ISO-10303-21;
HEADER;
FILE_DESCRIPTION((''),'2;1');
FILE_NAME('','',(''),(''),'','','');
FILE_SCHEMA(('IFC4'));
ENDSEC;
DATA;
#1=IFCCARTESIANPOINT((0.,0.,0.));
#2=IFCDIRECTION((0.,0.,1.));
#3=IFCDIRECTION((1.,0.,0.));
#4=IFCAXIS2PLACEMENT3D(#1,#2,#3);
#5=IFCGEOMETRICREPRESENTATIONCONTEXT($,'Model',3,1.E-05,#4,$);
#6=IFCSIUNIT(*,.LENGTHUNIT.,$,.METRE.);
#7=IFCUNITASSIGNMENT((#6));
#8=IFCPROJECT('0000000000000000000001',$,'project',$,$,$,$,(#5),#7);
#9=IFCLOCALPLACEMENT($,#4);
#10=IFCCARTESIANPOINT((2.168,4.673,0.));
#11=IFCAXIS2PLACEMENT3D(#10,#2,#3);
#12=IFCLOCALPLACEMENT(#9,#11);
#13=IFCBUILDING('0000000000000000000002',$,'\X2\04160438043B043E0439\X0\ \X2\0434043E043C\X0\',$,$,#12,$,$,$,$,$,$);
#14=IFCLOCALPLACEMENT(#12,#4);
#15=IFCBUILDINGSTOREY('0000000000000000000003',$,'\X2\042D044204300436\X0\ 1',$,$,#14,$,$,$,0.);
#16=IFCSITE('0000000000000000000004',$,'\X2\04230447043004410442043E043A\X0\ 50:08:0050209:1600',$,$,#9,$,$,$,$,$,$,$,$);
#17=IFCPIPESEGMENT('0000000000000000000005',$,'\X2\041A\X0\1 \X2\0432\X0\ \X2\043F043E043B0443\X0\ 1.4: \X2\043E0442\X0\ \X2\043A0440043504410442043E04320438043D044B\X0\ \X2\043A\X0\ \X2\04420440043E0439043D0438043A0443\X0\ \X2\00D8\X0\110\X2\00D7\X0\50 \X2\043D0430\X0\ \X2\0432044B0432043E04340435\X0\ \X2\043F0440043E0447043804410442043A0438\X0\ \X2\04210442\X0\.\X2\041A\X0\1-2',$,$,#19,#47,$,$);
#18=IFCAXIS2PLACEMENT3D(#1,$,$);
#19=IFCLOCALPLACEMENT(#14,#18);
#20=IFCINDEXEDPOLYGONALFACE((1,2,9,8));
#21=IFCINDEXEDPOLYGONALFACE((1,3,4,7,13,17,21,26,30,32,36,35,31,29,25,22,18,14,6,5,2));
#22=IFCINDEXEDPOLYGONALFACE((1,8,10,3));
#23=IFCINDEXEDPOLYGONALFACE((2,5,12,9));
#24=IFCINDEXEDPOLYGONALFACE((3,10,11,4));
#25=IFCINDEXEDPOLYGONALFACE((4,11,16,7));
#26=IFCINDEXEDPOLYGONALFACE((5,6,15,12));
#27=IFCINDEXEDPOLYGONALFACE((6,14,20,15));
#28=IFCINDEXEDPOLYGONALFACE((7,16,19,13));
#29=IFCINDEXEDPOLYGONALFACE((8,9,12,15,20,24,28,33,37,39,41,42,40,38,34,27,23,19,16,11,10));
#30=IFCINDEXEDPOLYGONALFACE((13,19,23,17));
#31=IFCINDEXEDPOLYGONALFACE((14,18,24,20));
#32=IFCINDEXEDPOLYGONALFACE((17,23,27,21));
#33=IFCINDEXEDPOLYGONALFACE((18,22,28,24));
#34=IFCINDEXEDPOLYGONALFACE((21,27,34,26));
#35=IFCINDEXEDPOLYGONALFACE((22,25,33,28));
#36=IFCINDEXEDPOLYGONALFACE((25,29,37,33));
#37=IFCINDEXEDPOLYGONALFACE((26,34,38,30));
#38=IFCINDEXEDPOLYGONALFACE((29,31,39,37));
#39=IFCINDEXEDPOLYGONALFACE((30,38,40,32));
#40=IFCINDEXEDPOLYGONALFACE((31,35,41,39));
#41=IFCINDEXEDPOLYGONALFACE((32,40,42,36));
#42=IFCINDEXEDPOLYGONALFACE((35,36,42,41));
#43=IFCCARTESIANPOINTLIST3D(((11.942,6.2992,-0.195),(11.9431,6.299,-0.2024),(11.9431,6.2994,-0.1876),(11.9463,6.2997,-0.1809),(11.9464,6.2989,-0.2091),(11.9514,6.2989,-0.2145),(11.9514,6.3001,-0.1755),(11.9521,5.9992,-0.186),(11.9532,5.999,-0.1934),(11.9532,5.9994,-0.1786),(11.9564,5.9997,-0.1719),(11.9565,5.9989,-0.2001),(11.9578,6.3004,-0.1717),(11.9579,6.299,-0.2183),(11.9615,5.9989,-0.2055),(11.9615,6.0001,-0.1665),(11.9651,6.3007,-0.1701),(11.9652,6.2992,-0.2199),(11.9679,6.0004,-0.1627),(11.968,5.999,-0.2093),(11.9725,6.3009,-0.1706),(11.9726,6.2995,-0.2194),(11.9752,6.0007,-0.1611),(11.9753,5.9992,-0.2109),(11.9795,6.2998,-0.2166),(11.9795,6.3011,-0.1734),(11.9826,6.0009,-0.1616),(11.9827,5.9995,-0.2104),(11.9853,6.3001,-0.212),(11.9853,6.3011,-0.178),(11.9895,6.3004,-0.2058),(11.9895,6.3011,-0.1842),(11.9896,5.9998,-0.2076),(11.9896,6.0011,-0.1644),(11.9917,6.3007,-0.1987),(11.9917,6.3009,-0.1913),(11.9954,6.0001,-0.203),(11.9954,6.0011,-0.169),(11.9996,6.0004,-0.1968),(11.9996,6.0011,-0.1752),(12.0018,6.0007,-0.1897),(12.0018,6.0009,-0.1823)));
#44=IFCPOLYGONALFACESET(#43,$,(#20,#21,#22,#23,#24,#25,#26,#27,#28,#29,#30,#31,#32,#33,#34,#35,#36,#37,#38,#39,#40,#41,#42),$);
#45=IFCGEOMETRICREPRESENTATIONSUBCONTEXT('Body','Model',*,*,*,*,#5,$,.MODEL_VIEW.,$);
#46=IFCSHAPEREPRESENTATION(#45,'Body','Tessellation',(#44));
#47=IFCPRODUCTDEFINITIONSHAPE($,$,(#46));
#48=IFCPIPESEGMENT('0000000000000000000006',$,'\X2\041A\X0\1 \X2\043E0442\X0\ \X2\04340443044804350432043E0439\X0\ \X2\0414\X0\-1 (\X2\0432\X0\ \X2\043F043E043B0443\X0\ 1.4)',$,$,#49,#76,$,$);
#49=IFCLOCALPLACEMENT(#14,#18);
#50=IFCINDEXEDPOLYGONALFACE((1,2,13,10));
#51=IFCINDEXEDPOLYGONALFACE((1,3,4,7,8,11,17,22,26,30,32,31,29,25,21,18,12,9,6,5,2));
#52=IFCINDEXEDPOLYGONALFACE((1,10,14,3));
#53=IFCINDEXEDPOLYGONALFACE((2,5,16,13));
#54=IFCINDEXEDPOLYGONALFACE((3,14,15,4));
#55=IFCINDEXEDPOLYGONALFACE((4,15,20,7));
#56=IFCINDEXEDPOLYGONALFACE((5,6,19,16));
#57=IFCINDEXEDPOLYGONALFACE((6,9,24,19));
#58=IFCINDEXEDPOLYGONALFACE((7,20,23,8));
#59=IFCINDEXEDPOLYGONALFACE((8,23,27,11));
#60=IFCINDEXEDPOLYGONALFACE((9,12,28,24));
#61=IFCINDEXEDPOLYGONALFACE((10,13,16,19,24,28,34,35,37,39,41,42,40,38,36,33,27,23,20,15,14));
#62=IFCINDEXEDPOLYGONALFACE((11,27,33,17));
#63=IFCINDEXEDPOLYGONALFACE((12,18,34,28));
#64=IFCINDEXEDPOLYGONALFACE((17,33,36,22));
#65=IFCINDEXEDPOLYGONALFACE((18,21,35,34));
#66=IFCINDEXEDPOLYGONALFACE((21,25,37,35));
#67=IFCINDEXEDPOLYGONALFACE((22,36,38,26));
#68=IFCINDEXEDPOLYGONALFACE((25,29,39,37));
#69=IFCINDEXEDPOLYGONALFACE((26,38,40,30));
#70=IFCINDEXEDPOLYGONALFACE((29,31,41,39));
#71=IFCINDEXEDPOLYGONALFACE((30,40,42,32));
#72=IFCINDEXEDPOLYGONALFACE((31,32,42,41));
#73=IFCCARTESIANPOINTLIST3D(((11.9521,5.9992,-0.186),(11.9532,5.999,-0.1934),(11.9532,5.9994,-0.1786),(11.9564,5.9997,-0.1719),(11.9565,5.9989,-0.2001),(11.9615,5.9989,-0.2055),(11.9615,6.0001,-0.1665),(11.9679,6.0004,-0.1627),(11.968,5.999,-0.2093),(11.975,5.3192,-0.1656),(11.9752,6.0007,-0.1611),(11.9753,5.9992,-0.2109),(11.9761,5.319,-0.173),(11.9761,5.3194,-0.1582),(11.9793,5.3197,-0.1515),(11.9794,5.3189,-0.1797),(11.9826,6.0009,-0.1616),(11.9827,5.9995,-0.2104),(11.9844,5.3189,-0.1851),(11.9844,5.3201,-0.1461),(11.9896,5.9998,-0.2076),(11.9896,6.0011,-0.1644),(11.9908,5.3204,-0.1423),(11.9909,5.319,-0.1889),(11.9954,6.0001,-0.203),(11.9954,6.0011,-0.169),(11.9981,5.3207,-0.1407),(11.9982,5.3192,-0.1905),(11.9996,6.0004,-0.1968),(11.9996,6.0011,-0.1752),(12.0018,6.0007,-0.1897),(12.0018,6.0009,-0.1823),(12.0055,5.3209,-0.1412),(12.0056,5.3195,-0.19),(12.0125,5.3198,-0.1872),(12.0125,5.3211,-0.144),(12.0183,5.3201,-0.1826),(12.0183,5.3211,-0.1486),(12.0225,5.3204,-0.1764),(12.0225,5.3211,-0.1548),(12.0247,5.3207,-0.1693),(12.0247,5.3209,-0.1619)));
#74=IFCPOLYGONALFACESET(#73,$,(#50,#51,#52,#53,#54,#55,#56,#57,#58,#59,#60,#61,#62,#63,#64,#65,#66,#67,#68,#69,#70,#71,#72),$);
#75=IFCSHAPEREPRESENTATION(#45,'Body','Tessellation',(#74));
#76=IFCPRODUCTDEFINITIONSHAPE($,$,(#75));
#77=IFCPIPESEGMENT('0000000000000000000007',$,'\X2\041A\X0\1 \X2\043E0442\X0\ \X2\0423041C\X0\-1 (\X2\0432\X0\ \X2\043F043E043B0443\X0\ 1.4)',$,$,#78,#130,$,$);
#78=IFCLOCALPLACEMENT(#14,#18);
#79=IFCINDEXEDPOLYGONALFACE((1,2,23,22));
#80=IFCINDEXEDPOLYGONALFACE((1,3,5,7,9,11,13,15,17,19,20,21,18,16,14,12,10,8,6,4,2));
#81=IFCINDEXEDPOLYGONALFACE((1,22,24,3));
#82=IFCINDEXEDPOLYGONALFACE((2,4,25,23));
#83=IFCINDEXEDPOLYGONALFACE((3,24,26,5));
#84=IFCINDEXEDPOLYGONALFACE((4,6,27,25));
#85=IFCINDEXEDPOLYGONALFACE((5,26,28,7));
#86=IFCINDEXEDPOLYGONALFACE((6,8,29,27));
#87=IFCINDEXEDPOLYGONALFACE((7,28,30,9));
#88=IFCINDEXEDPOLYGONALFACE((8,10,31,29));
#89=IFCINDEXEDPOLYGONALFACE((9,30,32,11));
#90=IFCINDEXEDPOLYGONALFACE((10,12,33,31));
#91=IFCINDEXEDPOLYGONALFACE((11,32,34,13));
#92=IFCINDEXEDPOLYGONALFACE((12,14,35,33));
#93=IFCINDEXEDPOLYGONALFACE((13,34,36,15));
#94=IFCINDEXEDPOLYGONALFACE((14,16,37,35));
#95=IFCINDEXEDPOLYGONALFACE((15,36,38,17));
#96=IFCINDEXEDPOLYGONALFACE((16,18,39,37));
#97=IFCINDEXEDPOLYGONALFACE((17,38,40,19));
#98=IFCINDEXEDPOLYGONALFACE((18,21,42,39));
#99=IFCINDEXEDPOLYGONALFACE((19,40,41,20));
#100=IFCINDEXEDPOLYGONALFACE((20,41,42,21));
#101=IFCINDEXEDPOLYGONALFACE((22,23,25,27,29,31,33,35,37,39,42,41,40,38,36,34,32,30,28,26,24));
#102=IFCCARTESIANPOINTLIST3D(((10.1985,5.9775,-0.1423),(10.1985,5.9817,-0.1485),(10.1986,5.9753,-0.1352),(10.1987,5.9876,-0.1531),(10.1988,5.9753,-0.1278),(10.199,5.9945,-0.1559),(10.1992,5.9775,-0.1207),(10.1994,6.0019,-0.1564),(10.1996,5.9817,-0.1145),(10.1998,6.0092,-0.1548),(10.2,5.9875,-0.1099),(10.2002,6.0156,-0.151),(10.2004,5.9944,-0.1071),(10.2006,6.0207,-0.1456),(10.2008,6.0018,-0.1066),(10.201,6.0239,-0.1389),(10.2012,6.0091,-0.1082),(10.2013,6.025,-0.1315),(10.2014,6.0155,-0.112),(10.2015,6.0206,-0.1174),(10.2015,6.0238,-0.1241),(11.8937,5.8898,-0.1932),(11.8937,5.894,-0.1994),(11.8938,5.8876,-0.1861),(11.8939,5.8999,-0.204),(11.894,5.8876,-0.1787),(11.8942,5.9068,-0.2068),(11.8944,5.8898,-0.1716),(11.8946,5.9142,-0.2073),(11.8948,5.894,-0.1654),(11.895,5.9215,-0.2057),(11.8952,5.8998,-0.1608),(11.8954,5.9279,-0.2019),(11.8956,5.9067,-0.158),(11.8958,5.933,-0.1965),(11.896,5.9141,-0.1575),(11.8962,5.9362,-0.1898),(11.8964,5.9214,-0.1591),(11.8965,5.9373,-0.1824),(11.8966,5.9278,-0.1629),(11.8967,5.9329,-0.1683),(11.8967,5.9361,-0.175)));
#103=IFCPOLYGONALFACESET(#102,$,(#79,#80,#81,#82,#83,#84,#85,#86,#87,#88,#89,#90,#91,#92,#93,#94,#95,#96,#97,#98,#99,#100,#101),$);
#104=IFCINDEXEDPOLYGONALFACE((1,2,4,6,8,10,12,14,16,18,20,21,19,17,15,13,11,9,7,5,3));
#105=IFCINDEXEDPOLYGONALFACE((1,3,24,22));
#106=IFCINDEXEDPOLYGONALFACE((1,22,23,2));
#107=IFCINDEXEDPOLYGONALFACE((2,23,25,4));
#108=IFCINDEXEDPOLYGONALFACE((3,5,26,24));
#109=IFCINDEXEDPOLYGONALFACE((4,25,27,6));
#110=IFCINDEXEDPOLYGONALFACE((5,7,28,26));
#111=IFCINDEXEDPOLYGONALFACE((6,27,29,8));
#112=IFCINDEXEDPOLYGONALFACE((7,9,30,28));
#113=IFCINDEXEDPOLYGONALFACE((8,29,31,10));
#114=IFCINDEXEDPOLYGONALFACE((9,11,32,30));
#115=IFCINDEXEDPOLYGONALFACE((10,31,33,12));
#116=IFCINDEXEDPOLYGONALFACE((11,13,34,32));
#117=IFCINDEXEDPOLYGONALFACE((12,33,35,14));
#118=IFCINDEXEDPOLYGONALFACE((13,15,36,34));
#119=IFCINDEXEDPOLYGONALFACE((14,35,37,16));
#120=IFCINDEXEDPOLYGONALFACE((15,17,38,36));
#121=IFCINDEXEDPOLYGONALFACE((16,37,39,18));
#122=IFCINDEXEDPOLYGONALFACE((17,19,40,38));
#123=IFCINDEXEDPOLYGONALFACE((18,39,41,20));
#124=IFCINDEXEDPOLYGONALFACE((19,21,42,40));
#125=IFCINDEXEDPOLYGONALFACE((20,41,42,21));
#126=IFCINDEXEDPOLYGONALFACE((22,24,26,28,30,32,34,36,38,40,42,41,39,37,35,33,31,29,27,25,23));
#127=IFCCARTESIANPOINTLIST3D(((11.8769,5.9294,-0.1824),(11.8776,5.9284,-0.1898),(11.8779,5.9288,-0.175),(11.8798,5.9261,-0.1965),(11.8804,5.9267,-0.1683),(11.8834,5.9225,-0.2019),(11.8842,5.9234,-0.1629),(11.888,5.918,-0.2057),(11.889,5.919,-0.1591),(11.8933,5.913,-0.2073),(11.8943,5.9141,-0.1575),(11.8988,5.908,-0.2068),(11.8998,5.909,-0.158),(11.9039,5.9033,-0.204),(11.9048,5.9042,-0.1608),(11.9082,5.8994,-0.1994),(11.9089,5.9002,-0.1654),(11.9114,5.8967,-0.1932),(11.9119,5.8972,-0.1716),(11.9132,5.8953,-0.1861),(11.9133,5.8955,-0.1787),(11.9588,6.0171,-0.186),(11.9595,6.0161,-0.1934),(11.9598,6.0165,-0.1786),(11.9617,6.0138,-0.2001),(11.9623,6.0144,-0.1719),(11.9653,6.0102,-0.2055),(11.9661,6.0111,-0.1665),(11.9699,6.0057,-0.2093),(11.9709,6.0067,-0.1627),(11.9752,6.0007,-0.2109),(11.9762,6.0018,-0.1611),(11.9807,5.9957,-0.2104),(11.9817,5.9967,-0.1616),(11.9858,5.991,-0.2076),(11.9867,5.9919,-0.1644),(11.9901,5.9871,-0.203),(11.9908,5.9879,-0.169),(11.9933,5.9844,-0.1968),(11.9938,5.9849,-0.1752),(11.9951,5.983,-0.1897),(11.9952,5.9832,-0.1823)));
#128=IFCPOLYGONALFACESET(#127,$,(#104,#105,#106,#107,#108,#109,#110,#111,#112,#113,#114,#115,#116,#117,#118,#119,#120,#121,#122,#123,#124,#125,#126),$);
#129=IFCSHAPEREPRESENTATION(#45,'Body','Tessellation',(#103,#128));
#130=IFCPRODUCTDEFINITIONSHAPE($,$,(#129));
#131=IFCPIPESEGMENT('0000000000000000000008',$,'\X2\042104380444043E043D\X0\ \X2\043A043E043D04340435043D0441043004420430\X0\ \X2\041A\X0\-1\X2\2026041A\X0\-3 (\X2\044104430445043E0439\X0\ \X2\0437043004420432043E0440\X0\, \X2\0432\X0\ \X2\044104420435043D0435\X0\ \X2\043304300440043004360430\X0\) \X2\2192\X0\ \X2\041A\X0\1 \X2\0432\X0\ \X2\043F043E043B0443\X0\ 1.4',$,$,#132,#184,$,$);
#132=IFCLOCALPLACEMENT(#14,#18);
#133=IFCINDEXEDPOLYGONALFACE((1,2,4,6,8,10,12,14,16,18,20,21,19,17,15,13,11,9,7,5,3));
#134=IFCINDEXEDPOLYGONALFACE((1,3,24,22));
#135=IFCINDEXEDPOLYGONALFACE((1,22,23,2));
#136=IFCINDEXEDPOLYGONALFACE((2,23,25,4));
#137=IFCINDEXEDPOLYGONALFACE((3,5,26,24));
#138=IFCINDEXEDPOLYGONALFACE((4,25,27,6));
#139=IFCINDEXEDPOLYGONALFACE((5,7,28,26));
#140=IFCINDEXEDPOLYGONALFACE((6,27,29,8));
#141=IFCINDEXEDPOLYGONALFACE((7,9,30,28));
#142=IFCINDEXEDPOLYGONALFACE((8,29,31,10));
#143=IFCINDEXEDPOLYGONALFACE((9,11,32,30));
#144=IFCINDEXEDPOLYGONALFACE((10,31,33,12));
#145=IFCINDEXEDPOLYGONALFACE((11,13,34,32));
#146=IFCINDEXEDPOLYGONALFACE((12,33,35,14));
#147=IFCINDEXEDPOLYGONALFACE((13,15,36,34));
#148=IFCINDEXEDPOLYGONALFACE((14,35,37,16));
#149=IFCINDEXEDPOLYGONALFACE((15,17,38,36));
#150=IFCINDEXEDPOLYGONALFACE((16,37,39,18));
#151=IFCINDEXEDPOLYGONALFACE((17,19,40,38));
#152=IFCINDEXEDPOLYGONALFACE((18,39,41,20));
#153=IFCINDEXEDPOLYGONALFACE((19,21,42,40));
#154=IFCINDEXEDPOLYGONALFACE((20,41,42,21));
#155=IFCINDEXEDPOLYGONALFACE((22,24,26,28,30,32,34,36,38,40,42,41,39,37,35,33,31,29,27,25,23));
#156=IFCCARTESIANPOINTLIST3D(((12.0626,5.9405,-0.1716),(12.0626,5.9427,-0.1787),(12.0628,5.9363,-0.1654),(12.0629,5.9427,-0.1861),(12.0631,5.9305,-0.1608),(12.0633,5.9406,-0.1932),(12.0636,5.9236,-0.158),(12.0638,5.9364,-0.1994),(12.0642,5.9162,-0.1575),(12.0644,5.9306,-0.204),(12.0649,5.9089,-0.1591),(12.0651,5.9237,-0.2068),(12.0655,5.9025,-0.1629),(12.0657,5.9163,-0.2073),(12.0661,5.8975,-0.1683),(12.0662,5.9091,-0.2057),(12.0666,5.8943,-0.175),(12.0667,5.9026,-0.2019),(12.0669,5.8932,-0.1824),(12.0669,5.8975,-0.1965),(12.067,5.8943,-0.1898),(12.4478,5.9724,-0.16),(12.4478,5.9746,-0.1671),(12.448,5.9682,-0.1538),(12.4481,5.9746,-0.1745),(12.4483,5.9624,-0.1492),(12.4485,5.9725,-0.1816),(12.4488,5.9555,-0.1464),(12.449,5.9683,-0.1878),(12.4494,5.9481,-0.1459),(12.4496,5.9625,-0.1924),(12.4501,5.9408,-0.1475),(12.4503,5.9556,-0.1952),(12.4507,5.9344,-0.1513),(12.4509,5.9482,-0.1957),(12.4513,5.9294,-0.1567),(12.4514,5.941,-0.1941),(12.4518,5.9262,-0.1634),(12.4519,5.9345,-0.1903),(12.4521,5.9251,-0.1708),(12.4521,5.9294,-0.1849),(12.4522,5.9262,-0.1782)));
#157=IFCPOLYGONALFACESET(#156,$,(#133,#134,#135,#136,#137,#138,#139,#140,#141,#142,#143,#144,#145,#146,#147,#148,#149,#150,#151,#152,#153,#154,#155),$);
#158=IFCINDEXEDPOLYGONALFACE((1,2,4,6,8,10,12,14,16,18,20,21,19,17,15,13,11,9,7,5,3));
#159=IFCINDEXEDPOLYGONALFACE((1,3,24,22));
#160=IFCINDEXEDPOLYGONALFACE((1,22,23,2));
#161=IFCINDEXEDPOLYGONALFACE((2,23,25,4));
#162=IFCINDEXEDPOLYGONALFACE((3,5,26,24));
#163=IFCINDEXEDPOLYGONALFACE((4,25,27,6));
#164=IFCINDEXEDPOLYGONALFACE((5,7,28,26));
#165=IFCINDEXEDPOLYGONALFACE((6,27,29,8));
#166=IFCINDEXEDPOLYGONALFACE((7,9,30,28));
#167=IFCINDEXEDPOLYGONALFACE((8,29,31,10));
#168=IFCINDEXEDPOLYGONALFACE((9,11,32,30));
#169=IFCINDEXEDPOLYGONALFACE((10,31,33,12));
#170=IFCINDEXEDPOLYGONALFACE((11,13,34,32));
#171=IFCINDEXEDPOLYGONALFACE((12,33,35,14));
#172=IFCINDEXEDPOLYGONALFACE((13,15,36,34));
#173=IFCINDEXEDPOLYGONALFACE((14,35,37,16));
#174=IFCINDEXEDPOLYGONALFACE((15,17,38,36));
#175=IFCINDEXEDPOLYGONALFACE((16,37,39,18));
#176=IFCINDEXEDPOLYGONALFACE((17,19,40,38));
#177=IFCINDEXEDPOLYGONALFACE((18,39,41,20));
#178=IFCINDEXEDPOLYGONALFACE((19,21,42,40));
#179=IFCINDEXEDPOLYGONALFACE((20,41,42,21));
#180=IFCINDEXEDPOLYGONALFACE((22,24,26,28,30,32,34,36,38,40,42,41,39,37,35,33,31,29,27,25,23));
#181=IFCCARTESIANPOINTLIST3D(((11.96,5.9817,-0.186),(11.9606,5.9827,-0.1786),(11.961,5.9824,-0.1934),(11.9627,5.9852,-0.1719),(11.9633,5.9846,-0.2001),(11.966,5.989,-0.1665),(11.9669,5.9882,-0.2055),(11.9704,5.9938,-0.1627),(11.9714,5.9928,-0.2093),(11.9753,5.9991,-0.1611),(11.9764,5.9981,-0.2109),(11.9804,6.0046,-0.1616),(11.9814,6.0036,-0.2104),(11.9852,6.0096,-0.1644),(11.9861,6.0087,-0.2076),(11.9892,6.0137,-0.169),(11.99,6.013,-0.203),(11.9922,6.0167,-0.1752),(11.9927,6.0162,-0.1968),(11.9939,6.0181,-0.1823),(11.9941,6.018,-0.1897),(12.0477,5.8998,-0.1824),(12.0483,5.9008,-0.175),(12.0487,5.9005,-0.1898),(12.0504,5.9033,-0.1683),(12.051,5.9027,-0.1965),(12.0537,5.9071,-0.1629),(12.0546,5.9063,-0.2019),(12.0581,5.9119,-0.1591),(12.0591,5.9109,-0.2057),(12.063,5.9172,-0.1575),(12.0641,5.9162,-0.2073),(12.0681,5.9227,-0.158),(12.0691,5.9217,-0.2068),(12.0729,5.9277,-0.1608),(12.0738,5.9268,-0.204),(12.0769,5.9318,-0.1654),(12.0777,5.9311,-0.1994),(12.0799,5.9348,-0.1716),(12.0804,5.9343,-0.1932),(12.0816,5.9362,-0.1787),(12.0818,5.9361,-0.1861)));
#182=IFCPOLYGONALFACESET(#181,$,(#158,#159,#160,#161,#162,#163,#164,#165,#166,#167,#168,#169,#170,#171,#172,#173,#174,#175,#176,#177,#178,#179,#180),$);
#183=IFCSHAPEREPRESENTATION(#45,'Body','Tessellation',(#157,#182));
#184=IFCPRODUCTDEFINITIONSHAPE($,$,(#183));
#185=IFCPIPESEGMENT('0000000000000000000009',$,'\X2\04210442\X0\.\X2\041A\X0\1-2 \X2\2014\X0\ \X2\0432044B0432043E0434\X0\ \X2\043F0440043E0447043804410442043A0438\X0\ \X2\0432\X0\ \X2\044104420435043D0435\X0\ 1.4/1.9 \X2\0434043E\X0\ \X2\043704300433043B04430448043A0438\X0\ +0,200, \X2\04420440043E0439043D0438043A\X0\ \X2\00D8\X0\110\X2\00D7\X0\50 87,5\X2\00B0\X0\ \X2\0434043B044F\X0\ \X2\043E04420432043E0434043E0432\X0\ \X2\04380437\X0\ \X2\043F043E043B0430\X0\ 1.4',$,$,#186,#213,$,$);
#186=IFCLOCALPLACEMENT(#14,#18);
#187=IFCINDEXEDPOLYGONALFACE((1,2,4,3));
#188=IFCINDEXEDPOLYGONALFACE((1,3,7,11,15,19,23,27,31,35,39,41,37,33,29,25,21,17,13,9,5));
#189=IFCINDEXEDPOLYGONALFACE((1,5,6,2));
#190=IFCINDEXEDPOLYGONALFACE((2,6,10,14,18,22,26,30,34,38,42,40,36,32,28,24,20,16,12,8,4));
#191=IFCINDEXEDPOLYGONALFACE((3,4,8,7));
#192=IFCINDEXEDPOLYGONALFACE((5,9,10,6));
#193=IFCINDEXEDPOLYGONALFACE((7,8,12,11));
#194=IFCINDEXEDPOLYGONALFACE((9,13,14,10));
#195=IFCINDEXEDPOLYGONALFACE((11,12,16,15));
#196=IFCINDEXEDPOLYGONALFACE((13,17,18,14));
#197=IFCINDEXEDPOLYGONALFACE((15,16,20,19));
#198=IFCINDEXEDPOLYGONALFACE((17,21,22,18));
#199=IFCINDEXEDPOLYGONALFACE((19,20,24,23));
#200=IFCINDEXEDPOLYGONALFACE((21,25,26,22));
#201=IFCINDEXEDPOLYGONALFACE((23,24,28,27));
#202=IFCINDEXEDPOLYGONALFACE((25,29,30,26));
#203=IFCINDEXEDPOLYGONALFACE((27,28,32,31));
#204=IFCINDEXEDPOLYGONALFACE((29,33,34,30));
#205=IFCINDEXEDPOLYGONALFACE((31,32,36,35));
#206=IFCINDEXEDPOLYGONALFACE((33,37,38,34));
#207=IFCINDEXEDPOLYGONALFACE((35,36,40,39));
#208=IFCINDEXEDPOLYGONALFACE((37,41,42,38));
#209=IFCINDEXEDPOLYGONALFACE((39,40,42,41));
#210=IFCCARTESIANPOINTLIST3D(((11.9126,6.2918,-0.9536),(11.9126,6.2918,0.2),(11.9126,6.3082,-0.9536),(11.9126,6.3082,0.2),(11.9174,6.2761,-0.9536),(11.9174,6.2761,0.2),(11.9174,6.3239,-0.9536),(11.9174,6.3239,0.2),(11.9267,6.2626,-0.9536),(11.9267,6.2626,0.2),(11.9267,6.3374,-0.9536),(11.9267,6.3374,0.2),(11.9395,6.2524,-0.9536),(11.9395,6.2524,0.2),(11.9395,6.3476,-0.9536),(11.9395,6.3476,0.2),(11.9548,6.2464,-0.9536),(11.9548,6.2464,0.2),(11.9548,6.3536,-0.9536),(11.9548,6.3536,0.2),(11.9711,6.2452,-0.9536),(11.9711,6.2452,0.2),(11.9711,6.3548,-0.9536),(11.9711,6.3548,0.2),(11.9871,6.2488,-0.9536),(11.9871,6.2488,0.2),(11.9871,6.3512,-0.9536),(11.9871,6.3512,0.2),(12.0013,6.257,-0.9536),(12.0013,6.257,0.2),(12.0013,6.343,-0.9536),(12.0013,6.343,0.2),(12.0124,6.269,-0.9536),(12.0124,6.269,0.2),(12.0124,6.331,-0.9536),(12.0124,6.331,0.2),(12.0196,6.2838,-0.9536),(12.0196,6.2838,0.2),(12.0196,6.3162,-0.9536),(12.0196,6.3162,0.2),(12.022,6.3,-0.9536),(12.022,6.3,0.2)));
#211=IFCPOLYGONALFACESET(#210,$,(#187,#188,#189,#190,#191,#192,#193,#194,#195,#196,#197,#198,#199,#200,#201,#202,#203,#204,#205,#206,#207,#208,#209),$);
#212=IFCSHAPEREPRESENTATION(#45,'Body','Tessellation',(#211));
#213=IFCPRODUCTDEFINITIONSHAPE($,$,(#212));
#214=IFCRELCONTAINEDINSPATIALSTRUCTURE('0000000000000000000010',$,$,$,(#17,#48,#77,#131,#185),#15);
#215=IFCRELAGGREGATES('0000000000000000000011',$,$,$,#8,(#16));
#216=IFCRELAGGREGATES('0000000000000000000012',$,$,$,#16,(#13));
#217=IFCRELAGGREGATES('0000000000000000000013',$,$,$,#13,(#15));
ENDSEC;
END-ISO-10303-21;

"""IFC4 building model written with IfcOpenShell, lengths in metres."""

from ifc_helpers import new_model, si_unit, frame, origin_with_axes, origin_2d, place, context, subcontext, project, spatial, circle, extrude, element, save


model = new_model("IFC4")

# Units and contexts
model_context = context("Model", 3, precision=1e-05, world=origin_with_axes())
body_context = subcontext(model_context, "Body", "Model", "MODEL_VIEW")
ifc_project = project(units=[si_unit("LENGTHUNIT", "METRE")], contexts=[model_context])

# Site, building, storey
site_placement = place(None, origin_with_axes())
site = spatial("IfcSite", under=ifc_project, at=site_placement, Name="Участок 50:08:0050209:1600")
building_placement = place(site_placement, frame((2.168, 4.673, 0.0), z_axis=(0.0, 0.0, 1.0), x_axis=(1.0, 0.0, 0.0)))
building = spatial("IfcBuilding", under=site, at=building_placement, Name="Жилой дом")
storey_placement = place(building_placement, origin_with_axes())
storey = spatial("IfcBuildingStorey", under=building, at=storey_placement, Name="Этаж 1", Elevation=0.0)

# Pipe segments
pipe_segment_1_placement = place(storey_placement, origin_with_axes())
element("IfcPipeSegment", 1, at=pipe_segment_1_placement, inside=storey, Name="К1 в полу 1.4: от крестовины к тройнику Ø110×50 на выводе прочистки Ст.К1-2", context=body_context, shape_type="SweptSolid", body=[
    extrude(circle(Radius=0.025, at=origin_2d()), frame((11.9771, 6.0, -0.186), z_axis=(-0.033632, 0.998985, -0.02997), x_axis=(-0.999434, -0.033648, 0.0)), (0.0, 0.0, 1.0), 0.3003),
])
pipe_segment_2_placement = place(storey_placement, origin_with_axes())
element("IfcPipeSegment", 2, at=pipe_segment_2_placement, inside=storey, Name="К1 от душевой Д-1 (в полу 1.4)", context=body_context, shape_type="SweptSolid", body=[
    extrude(circle(Radius=0.025, at=origin_2d()), frame((12.0, 5.32, -0.1656), z_axis=(-0.033642, 0.998984, -0.02997), x_axis=(-0.999433, -0.033657, 0.0)), (0.0, 0.0, 1.0), 0.6807),
])
pipe_segment_3_placement = place(storey_placement, origin_with_axes())
element("IfcPipeSegment", 3, at=pipe_segment_3_placement, inside=storey, Name="К1 от УМ-1 (в полу 1.4)", context=body_context, shape_type="SweptSolid", body=[
    extrude(circle(Radius=0.025, at=origin_2d()), frame((10.2, 6.0, -0.1315), z_axis=(0.998216, -0.051642, -0.029972), x_axis=(0.051665, 0.998664, 0.0)), (0.0, 0.0, 1.0), 1.6982),
    extrude(circle(Radius=0.025, at=origin_2d()), frame((11.8952, 5.9123, -0.1824), z_axis=(0.682219, 0.730533, -0.029988), x_axis=(-0.730861, 0.682526, 0.0)), (0.0, 0.0, 1.0), 0.12),
])
pipe_segment_4_placement = place(storey_placement, origin_with_axes())
element("IfcPipeSegment", 4, at=pipe_segment_4_placement, inside=storey, Name="Сифон конденсата К-1…К-3 (сухой затвор, в стене гаража) → К1 в полу 1.4", context=body_context, shape_type="SweptSolid", body=[
    extrude(circle(Radius=0.025, at=origin_2d()), frame((12.45, 5.95, -0.1708), z_axis=(-0.99614, -0.082494, -0.029998), x_axis=(0.082532, -0.996588, 0.0)), (0.0, 0.0, 1.0), 0.3867),
    extrude(circle(Radius=0.025, at=origin_2d()), frame((12.0648, 5.9181, -0.1824), z_axis=(-0.730533, 0.682219, -0.029988), x_axis=(-0.682526, -0.730861, 0.0)), (0.0, 0.0, 1.0), 0.12),
])
pipe_segment_5_placement = place(storey_placement, origin_with_axes())
element("IfcPipeSegment", 5, at=pipe_segment_5_placement, inside=storey, Name="Ст.К1-2 — вывод прочистки в стене 1.4/1.9 до заглушки +0,200, тройник Ø110×50 87,5° для отводов из пола 1.4", context=body_context, shape_type="SweptSolid", body=[
    extrude(circle(Radius=0.055, at=origin_2d()), frame((11.967, 6.3, -0.9536), z_axis=(0.0, 0.0, 1.0), x_axis=(1.0, 0.0, 0.0)), (0.0, 0.0, 1.0), 1.1536),
])

save(model, "model.ifc")
